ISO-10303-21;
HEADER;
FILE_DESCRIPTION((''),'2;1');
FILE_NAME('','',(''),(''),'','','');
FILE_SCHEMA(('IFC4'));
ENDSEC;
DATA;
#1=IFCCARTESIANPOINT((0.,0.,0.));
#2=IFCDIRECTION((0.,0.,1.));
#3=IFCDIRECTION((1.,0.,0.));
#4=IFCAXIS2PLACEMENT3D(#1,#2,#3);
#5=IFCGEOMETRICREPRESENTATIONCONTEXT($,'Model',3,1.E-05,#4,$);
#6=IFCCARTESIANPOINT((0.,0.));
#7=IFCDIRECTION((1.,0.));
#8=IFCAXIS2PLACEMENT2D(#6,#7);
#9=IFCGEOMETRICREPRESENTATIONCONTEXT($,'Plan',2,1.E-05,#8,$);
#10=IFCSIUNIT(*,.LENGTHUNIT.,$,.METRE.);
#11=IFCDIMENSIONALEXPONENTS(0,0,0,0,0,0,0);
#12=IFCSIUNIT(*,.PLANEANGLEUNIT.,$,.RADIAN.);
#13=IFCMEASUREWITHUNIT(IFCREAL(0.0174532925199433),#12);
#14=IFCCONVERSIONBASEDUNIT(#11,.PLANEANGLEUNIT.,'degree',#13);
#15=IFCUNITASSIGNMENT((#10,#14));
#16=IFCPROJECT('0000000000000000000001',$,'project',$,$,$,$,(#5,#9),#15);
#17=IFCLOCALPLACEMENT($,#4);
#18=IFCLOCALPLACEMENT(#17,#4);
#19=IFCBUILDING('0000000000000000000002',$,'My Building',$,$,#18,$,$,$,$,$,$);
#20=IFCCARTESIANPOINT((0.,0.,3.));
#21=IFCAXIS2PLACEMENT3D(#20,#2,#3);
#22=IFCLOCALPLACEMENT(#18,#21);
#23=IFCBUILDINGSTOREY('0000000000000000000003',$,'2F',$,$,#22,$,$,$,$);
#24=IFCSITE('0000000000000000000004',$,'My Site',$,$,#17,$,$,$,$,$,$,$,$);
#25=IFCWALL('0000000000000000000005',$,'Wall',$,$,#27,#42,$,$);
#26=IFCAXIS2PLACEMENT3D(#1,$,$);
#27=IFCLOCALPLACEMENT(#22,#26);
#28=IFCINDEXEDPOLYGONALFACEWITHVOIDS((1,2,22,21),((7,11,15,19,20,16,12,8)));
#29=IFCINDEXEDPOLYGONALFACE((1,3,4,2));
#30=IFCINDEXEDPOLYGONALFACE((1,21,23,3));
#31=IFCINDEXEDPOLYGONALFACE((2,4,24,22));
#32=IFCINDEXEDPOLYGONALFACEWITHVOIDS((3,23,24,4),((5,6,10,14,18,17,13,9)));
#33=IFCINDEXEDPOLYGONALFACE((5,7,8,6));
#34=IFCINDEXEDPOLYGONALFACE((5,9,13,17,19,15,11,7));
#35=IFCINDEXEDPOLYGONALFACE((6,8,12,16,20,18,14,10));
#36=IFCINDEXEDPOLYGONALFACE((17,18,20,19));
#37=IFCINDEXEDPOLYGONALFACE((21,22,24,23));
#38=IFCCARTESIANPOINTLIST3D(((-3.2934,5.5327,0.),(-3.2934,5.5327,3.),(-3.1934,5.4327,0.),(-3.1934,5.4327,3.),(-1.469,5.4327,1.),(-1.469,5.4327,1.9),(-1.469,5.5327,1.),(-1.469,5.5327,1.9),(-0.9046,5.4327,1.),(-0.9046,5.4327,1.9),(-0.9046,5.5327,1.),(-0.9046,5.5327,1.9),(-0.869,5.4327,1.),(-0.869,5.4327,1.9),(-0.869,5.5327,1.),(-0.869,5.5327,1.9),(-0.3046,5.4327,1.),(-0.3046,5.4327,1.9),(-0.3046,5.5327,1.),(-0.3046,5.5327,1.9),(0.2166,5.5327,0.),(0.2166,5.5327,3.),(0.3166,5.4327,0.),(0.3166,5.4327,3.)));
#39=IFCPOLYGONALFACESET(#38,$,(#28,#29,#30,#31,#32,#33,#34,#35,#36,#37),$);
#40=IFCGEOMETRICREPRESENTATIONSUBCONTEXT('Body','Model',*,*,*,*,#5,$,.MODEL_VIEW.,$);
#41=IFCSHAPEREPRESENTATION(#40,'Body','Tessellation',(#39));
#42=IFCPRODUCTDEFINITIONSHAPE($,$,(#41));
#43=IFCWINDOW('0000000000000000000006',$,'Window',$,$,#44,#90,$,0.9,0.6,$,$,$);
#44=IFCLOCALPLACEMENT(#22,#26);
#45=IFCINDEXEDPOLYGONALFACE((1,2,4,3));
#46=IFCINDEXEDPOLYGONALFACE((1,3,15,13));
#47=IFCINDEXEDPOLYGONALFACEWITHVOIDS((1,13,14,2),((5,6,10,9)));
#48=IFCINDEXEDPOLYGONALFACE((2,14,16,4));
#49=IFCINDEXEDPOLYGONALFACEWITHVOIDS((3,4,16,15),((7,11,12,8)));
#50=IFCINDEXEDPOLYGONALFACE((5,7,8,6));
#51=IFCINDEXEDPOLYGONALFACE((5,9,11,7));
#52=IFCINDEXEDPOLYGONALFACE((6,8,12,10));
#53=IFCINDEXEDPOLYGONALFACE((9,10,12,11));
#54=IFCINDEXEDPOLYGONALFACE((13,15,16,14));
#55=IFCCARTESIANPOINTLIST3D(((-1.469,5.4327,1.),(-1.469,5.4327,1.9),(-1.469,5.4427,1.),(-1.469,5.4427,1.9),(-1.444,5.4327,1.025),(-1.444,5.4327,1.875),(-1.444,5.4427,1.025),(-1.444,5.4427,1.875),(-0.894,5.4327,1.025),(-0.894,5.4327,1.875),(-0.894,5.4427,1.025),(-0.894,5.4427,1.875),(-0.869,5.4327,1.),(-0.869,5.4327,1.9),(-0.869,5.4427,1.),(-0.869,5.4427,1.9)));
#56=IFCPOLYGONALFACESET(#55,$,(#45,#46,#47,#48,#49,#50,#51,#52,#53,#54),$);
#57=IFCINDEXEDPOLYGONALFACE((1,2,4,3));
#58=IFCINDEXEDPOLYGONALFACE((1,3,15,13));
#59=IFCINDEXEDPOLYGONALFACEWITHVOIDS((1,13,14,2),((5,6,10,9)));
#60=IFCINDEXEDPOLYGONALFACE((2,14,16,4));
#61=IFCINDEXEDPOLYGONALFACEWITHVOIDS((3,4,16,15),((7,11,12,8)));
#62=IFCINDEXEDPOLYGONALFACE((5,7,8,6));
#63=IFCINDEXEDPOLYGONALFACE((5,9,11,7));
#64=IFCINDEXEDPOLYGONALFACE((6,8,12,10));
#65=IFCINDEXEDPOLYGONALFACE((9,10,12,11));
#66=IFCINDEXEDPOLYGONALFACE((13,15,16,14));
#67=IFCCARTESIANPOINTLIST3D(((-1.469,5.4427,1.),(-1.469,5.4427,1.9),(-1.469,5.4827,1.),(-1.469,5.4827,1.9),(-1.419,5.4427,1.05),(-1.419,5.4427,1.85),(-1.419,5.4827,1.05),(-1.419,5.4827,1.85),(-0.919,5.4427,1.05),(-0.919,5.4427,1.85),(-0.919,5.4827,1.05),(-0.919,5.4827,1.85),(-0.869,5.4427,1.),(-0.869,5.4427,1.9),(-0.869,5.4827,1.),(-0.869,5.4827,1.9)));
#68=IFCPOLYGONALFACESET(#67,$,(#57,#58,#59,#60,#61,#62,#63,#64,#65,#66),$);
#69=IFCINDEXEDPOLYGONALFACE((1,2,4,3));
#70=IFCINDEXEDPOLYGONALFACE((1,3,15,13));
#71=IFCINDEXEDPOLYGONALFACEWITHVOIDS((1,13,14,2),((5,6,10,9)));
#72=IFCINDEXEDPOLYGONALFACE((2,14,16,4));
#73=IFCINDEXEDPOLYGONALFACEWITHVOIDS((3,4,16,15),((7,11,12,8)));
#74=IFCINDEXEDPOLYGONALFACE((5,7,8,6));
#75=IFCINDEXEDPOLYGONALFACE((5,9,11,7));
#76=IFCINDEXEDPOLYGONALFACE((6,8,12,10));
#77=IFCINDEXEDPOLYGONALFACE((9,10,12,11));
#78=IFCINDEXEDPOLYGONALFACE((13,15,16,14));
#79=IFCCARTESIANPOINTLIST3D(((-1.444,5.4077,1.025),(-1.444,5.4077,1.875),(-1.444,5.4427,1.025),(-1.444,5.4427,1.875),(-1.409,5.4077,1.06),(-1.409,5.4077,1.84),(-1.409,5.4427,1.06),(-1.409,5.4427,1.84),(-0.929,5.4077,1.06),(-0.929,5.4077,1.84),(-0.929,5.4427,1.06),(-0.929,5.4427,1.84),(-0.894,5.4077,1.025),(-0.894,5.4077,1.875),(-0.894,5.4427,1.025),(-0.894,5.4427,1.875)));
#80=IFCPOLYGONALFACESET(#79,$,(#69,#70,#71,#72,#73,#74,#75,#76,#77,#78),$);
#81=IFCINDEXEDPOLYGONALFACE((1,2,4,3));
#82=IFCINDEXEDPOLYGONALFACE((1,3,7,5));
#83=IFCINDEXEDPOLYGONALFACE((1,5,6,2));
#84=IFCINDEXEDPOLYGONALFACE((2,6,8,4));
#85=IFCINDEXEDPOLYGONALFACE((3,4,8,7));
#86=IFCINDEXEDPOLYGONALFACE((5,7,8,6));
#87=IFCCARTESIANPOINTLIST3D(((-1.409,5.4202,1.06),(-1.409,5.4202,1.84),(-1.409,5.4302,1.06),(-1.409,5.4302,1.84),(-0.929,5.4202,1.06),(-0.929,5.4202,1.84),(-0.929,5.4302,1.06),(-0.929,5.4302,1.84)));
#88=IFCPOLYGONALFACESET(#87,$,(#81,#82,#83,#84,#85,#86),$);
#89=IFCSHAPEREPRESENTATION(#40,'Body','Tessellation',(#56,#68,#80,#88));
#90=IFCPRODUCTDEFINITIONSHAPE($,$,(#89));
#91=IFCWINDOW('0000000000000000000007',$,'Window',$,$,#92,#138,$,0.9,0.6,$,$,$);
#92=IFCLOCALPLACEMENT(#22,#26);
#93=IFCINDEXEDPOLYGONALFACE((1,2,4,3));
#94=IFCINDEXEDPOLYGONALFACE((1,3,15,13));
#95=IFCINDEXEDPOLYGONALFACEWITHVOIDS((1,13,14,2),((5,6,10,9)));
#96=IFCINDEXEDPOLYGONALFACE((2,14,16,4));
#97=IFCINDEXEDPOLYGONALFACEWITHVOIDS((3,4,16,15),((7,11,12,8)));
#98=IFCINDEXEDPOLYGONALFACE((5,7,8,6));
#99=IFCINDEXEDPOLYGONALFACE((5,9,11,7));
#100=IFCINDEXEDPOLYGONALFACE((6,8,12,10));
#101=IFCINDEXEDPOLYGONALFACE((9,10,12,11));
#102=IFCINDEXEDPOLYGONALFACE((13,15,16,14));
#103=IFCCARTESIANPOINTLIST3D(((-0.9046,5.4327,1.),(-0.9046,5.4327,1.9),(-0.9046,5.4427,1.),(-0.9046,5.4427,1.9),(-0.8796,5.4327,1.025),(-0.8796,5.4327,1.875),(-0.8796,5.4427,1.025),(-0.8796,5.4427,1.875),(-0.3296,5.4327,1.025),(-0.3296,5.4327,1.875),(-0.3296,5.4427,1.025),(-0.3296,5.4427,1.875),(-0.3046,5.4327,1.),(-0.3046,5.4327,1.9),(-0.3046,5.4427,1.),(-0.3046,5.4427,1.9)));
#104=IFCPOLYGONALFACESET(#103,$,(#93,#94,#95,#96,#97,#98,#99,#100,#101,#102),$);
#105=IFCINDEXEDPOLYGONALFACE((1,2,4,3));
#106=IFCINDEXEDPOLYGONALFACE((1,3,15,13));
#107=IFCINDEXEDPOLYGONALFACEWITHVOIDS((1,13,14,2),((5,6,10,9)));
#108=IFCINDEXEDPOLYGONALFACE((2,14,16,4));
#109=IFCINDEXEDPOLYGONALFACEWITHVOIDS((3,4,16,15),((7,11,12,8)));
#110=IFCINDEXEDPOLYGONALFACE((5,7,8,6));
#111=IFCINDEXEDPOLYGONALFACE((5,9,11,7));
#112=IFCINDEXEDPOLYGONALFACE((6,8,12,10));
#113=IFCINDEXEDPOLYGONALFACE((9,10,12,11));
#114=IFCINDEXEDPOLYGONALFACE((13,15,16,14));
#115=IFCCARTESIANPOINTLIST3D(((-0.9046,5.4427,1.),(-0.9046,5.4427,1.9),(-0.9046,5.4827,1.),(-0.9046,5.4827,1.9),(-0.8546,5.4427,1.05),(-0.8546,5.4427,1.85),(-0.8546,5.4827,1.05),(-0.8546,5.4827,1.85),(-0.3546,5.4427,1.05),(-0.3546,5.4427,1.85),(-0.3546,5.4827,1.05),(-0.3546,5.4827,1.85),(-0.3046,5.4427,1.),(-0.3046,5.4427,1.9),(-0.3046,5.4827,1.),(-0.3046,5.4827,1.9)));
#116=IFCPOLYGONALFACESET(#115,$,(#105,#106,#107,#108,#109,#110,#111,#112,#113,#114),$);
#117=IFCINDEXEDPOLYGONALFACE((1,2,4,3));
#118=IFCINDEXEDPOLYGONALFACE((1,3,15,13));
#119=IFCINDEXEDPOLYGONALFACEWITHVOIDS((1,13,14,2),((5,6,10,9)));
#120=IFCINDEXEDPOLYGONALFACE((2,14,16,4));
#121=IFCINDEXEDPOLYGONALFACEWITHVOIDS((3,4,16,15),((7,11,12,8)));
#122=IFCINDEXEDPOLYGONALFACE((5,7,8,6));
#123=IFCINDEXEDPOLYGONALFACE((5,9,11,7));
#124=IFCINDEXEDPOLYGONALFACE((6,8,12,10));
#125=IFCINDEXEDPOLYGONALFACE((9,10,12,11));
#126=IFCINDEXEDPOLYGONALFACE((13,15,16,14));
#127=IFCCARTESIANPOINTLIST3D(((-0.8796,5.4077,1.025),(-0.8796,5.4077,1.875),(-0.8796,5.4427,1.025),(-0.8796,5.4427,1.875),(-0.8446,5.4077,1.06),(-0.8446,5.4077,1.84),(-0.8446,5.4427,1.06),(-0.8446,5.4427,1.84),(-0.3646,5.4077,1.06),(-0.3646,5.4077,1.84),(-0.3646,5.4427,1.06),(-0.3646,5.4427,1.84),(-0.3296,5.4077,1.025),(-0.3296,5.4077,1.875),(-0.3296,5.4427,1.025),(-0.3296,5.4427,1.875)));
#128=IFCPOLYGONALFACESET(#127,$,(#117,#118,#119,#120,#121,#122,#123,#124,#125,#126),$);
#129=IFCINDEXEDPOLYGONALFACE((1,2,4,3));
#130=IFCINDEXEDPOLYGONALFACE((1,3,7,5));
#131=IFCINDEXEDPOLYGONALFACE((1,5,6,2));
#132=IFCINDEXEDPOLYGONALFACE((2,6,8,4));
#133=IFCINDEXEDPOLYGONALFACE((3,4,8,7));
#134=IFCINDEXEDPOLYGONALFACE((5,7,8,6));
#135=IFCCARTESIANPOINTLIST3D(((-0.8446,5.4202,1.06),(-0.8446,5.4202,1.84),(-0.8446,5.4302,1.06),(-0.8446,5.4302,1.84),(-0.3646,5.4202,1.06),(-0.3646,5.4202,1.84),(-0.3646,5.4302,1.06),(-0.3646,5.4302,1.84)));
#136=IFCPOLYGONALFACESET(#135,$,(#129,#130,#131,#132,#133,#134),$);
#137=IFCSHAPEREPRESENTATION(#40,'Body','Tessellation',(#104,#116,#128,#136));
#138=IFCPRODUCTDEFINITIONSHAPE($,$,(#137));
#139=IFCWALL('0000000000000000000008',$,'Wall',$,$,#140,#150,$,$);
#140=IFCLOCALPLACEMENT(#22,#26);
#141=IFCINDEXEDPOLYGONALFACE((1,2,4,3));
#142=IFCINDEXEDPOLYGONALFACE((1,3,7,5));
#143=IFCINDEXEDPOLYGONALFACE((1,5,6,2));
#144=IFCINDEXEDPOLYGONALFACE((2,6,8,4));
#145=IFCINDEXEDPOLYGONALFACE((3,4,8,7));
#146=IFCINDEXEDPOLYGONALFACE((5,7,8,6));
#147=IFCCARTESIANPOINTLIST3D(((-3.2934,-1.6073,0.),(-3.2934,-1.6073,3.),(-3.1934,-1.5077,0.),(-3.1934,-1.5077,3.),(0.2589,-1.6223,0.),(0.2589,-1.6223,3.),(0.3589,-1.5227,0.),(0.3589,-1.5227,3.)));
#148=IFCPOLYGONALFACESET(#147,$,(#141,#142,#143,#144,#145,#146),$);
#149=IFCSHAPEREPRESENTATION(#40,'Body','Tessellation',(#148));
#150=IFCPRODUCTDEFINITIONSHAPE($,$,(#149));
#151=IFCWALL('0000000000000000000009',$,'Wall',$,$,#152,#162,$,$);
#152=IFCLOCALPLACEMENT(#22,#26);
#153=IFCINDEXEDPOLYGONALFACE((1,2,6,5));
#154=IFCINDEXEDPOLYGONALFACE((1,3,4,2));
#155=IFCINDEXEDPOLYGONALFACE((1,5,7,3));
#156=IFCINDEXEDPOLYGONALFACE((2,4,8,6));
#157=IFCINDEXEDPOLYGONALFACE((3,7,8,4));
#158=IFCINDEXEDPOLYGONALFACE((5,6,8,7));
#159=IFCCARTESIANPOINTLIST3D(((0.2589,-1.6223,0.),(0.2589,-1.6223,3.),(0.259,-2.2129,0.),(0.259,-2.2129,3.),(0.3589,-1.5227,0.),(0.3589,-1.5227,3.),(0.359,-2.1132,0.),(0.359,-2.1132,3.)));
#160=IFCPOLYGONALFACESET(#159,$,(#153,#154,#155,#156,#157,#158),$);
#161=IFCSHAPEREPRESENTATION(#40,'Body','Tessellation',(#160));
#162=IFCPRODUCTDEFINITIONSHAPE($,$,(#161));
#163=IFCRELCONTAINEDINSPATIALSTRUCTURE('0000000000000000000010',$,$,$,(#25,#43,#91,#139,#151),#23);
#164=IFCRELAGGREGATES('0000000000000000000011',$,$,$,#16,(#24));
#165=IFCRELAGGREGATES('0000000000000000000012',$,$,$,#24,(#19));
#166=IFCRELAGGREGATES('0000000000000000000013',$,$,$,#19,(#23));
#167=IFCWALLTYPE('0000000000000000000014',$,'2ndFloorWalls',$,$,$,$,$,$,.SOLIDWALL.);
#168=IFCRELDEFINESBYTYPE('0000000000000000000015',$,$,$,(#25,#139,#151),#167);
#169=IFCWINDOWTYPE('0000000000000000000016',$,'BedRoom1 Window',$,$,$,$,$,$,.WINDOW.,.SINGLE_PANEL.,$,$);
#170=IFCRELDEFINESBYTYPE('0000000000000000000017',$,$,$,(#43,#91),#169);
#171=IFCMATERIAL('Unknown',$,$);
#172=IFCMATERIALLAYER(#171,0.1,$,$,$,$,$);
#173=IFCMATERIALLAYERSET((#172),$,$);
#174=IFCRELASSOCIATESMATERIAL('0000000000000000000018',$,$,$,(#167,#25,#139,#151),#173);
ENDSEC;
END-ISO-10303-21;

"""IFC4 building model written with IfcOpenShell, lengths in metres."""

from ifc_helpers import new_model, entity, si_unit, converted_unit, frame, origin_with_axes, origin_2d_with_axis, place, context, subcontext, project, spatial, line, indexed_curve, outline, extrude, shape, source, transform, mapped, material, layer, layer_set, layer_usage, type_object, type_shapes, element, fill, save


model = new_model("IFC4")

# Units and contexts
model_context = context("Model", 3, precision=1e-05, world=origin_with_axes())
plan_context = context("Plan", 2, precision=1e-05, world=origin_2d_with_axis())
body_context_1 = subcontext(model_context, "Body", "Model", "MODEL_VIEW")
body_context_2 = subcontext(plan_context, "Body", "Plan", "PLAN_VIEW")
ifc_project = project(units=[si_unit("LENGTHUNIT", "METRE"), converted_unit("PLANEANGLEUNIT", "degree", entity("IfcReal", 0.0174532925199433), si_unit("PLANEANGLEUNIT", "RADIAN"), dimensions=[0, 0, 0, 0, 0, 0, 0])], contexts=[model_context, plan_context])

# Site, building, storey
site_placement = place(None, origin_with_axes())
site = spatial("IfcSite", under=ifc_project, at=site_placement, Name="My Site")
building_placement = place(site_placement, origin_with_axes())
building = spatial("IfcBuilding", under=site, at=building_placement, Name="My Building")
storey_placement = place(building_placement, frame((0.0, 0.0, 3.0), z_axis=(0.0, 0.0, 1.0), x_axis=(1.0, 0.0, 0.0)))
storey = spatial("IfcBuildingStorey", under=building, at=storey_placement, Name="2F")

# Shared definitions
ifc_material = material(Name="Unknown")

# Shared definitions
ifc_layer_1 = layer(ifc_material, 0.1)
ifc_layer_set_1 = layer_set([ifc_layer_1])
wall_type = type_object("IfcWallType", Name="2ndFloorWalls", PredefinedType="SOLIDWALL", material=ifc_layer_set_1)

# Wall, openings, windows
ifc_layer_usage_1 = layer_usage(ifc_layer_set_1, "AXIS2", "POSITIVE", 0.0)
wall_1_placement = place(storey_placement, frame((0.2166, 5.5327, 0.0), z_axis=(0.0, 0.0, 1.0), x_axis=(-1.0, 0.0, 0.0)))
wall_1 = element("IfcWall", 1, at=wall_1_placement, inside=storey, type_object=wall_type, material=ifc_layer_usage_1, Name="Wall", context=body_context_1, shape_type="SweptSolid", body=[
    extrude(outline(indexed_curve([(0.0, 0.0), (-0.1, 0.1), (3.41, 0.1), (3.51, 0.0)], segments=[line(1, 2, 3, 4, 1)])), origin_with_axes(), (0.0, 0.0, 1.0), 3.0),
])
shared_shape_1 = source(origin_with_axes(), body_context_1, "Body", "SweptSolid", [
    extrude(outline(indexed_curve([(0.0, 0.0), (0.6, 0.0), (0.6, 0.9), (0.0, 0.9)], segments=[line(1, 2, 3, 4, 1)])), frame((0.0, -0.6, 0.0), z_axis=(0.0, -1.0, 0.0), x_axis=(1.0, 0.0, 0.0)), (0.0, 0.0, -1.0), 1.2),
])
opening_1_placement = place(wall_1_placement, frame((1.0856, 0.0, 1.0), z_axis=(0.0, 0.0, 1.0), x_axis=(1.0, 0.0, 0.0)))
opening_1 = element("IfcOpeningElement", 2, at=opening_1_placement, cuts=wall_1, PredefinedType="OPENING", context=body_context_1, shape_type="MappedRepresentation", body=[
    mapped(shared_shape_1, transform((0.0, 0.0, 0.0), x_axis=(1.0, 0.0, 0.0), y_axis=(0.0, 1.0, 0.0), z_axis=(0.0, 0.0, 1.0), scale=1.0)),
])
opening_2_placement = place(wall_1_placement, frame((0.5212, 0.0, 1.0), z_axis=(0.0, 0.0, 1.0), x_axis=(1.0, 0.0, 0.0)))
opening_2 = element("IfcOpeningElement", 3, at=opening_2_placement, cuts=wall_1, PredefinedType="OPENING", context=body_context_1, shape_type="MappedRepresentation", body=[
    mapped(shared_shape_1, transform((0.0, 0.0, 0.0), x_axis=(1.0, 0.0, 0.0), y_axis=(0.0, 1.0, 0.0), z_axis=(0.0, 0.0, 1.0), scale=1.0)),
])
window_type_1 = type_object("IfcWindowType", Name="BedRoom1 Window", PartitioningType="SINGLE_PANEL", PredefinedType="WINDOW")
shared_shape_2 = source(origin_with_axes(), body_context_1, "Body", "SweptSolid", [
    extrude(outline(indexed_curve([(0.0, 0.0), (0.6, 0.0), (0.6, 0.9), (0.0, 0.9)], segments=[line(1, 2, 3, 4, 1)]), holes=[indexed_curve([(0.025, 0.025), (0.575, 0.025), (0.575, 0.875), (0.025, 0.875)], segments=[line(1, 2, 3, 4, 1)])]), frame((0.0, 0.09, 0.0), z_axis=(0.0, -1.0, 0.0), x_axis=(1.0, 0.0, 0.0)), (0.0, 0.0, -1.0), 0.01),
    extrude(outline(indexed_curve([(0.0, 0.0), (0.6, 0.0), (0.6, 0.9), (0.0, 0.9)], segments=[line(1, 2, 3, 4, 1)]), holes=[indexed_curve([(0.05, 0.05), (0.55, 0.05), (0.55, 0.85), (0.05, 0.85)], segments=[line(1, 2, 3, 4, 1)])]), frame((0.0, 0.05, 0.0), z_axis=(0.0, -1.0, 0.0), x_axis=(1.0, 0.0, 0.0)), (0.0, 0.0, -1.0), 0.04),
    extrude(outline(indexed_curve([(0.0, 0.0), (0.55, 0.0), (0.55, 0.85), (0.0, 0.85)], segments=[line(1, 2, 3, 4, 1)]), holes=[indexed_curve([(0.035, 0.035), (0.515, 0.035), (0.515, 0.815), (0.035, 0.815)], segments=[line(1, 2, 3, 4, 1)])]), frame((0.025, 0.09, 0.025), z_axis=(0.0, -1.0, 0.0), x_axis=(1.0, 0.0, 0.0)), (0.0, 0.0, -1.0), 0.035),
    extrude(outline(indexed_curve([(0.035, 0.035), (0.515, 0.035), (0.515, 0.815), (0.035, 0.815)], segments=[line(1, 2, 3, 4, 1)])), frame((0.025, 0.1025, 0.025), z_axis=(0.0, -1.0, 0.0), x_axis=(1.0, 0.0, 0.0)), (0.0, 0.0, -1.0), 0.01),
])
shared_shape_3 = source(origin_with_axes(), body_context_2, "Body", "Curve2D", [
    entity("IfcIndexedPolyCurve", entity("IfcCartesianPointList2D", [[0.05, 0.05], [0.55, 0.05]])),
    entity("IfcIndexedPolyCurve", entity("IfcCartesianPointList2D", [[0.0, 0.1], [0.025, 0.1], [0.025, 0.09], [0.05, 0.09], [0.05, 0.05], [0.0, 0.05]]), [entity("IfcLineIndex", [1, 2, 3, 4, 5, 6, 1])]),
    entity("IfcIndexedPolyCurve", entity("IfcCartesianPointList2D", [[0.6, 0.1], [0.575, 0.1], [0.575, 0.09], [0.55, 0.09], [0.55, 0.05], [0.6, 0.05]]), [entity("IfcLineIndex", [1, 2, 3, 4, 5, 6, 1])]),
    entity("IfcIndexedPolyCurve", entity("IfcCartesianPointList2D", [[0.025, 0.09], [0.06, 0.09], [0.06, 0.125], [0.025, 0.125]]), [entity("IfcLineIndex", [1, 2, 3, 4, 1])]),
    entity("IfcIndexedPolyCurve", entity("IfcCartesianPointList2D", [[0.575, 0.09], [0.54, 0.09], [0.54, 0.125], [0.575, 0.125]]), [entity("IfcLineIndex", [1, 2, 3, 4, 1])]),
    entity("IfcIndexedPolyCurve", entity("IfcCartesianPointList2D", [[0.06, 0.09], [0.54, 0.09]])),
    entity("IfcIndexedPolyCurve", entity("IfcCartesianPointList2D", [[0.06, 0.125], [0.54, 0.125]])),
    entity("IfcIndexedPolyCurve", entity("IfcCartesianPointList2D", [[0.06, 0.1075], [0.54, 0.1075]])),
])
type_shapes(window_type_1, [shared_shape_2, shared_shape_3])
window_1_placement = place(opening_1_placement, origin_with_axes())
window_1 = element("IfcWindow", 4, at=window_1_placement, inside=storey, type_object=window_type_1, Name="Window", OverallHeight=0.9, OverallWidth=0.6, shapes=[
    shape(body_context_1, "Body", "MappedRepresentation", [mapped(shared_shape_2, transform((0.0, 0.0, 0.0), x_axis=(1.0, 0.0, 0.0), y_axis=(0.0, 1.0, 0.0), z_axis=(0.0, 0.0, 1.0), scale=1.0))]),
    shape(body_context_2, "Body", "MappedRepresentation", [mapped(shared_shape_3, transform((0.0, 0.0, 0.0), x_axis=(1.0, 0.0, 0.0), y_axis=(0.0, 1.0, 0.0), z_axis=(0.0, 0.0, 1.0), scale=1.0))]),
])
fill(opening_1, window_1)
window_2_placement = place(opening_2_placement, origin_with_axes())
window_2 = element("IfcWindow", 5, at=window_2_placement, inside=storey, type_object=window_type_1, Name="Window", OverallHeight=0.9, OverallWidth=0.6, shapes=[
    shape(body_context_1, "Body", "MappedRepresentation", [mapped(shared_shape_2, transform((0.0, 0.0, 0.0), x_axis=(1.0, 0.0, 0.0), y_axis=(0.0, 1.0, 0.0), z_axis=(0.0, 0.0, 1.0), scale=1.0))]),
    shape(body_context_2, "Body", "MappedRepresentation", [mapped(shared_shape_3, transform((0.0, 0.0, 0.0), x_axis=(1.0, 0.0, 0.0), y_axis=(0.0, 1.0, 0.0), z_axis=(0.0, 0.0, 1.0), scale=1.0))]),
])
fill(opening_2, window_2)

# Walls
ifc_layer_usage_2 = layer_usage(ifc_layer_set_1, "AXIS2", "POSITIVE", 0.0)
wall_2_placement = place(storey_placement, frame((-3.2934, -1.6073, 0.0), z_axis=(0.0, 0.0, 1.0), x_axis=(0.999991, -0.004229, 0.0)))
element("IfcWall", 6, at=wall_2_placement, inside=storey, type_object=wall_type, material=ifc_layer_usage_2, Name="Wall", context=body_context_1, shape_type="SweptSolid", body=[
    extrude(outline(indexed_curve([(0.0, 0.0), (0.0996, 0.1), (3.6519, 0.1), (3.5523, 0.0)], segments=[line(1, 2, 3, 4, 1)])), origin_with_axes(), (0.0, 0.0, 1.0), 3.0),
])
ifc_layer_usage_3 = layer_usage(ifc_layer_set_1, "AXIS2", "POSITIVE", 0.0)
wall_3_placement = place(storey_placement, frame((0.2589, -1.6223, 0.0), z_axis=(0.0, 0.0, 1.0), x_axis=(0.000177, -1.0, 0.0)))
element("IfcWall", 7, at=wall_3_placement, inside=storey, type_object=wall_type, material=ifc_layer_usage_3, Name="Wall", context=body_context_1, shape_type="SweptSolid", body=[
    extrude(outline(indexed_curve([(0.0, 0.0), (-0.0996, 0.1), (0.4909, 0.1), (0.5905, 0.0)], segments=[line(1, 2, 3, 4, 1)])), origin_with_axes(), (0.0, 0.0, 1.0), 3.0),
])

save(model, "model.ifc")
